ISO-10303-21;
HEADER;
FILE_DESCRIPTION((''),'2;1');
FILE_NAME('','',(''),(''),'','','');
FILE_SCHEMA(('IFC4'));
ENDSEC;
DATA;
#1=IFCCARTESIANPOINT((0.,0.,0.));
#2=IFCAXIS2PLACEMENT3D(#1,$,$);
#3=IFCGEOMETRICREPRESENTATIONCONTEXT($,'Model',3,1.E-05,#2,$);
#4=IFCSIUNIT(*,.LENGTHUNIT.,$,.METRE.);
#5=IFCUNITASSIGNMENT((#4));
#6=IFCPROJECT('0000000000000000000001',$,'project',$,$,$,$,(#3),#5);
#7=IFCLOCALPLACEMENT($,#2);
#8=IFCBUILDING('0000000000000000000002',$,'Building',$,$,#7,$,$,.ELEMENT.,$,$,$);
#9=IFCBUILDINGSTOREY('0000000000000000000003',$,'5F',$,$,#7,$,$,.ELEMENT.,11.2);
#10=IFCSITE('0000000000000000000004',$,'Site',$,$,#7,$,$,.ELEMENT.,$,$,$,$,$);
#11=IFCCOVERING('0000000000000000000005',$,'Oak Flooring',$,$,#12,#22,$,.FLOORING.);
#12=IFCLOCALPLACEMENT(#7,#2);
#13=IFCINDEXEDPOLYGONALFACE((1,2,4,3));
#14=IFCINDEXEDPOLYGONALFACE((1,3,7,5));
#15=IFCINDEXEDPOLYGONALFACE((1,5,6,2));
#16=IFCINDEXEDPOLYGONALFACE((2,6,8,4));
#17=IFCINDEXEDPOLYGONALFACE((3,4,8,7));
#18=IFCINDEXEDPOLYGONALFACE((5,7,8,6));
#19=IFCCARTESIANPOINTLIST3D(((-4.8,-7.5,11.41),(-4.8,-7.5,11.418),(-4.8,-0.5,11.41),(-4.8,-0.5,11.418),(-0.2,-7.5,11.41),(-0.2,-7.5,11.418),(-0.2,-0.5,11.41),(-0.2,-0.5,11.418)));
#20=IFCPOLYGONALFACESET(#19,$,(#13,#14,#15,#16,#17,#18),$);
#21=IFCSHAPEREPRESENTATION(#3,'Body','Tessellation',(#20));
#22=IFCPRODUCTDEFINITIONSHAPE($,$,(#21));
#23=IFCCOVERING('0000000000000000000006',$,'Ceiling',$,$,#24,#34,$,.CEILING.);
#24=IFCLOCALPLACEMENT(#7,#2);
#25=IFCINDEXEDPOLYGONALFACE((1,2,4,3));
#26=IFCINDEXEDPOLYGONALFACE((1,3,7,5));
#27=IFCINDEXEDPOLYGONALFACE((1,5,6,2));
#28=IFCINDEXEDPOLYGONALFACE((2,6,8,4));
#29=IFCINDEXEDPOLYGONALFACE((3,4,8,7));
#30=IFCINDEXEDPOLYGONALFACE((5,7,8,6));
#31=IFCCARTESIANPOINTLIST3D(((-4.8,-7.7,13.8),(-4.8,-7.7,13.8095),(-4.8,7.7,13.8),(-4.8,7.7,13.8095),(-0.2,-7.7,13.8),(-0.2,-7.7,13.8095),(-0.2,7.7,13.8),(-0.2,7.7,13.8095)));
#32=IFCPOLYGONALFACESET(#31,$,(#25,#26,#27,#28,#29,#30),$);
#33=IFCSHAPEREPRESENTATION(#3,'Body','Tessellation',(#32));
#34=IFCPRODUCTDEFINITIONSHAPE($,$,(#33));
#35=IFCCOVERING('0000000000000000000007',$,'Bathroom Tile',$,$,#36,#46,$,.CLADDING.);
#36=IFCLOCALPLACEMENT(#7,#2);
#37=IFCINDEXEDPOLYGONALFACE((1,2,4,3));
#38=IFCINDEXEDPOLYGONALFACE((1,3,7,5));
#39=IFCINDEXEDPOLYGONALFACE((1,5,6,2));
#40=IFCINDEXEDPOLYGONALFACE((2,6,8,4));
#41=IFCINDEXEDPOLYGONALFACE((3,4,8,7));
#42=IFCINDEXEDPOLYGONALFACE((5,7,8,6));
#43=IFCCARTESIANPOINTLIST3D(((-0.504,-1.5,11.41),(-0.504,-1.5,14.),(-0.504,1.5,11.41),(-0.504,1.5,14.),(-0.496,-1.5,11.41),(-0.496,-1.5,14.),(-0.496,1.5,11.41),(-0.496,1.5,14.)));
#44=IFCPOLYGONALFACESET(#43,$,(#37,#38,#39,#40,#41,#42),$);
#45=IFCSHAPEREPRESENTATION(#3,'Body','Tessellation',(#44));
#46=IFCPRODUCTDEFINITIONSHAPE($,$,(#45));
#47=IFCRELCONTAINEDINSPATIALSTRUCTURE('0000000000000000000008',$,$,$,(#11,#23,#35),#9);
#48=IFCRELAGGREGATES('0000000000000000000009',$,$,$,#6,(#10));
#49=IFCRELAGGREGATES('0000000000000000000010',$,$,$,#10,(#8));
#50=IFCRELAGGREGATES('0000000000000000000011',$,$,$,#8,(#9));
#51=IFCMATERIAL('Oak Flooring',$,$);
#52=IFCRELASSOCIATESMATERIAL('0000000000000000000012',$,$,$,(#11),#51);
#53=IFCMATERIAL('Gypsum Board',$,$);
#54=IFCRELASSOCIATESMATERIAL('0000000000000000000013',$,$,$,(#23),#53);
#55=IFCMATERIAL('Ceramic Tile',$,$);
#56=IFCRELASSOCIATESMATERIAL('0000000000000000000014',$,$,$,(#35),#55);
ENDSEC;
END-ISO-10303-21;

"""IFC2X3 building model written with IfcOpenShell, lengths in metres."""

from ifc_helpers import new_model, si_unit, frame, origin, origin_2d, place, context, project, spatial, rectangle, extrude, material, element, save


model = new_model("IFC2X3")

# Units and contexts
model_context = context("Model", 3, precision=1e-05, world=origin())
ifc_project = project(units=[si_unit("LENGTHUNIT", "METRE")], contexts=[model_context])

# Site, building, storey
placement = place(None, origin())
site = spatial("IfcSite", under=ifc_project, at=placement, Name="Site", CompositionType="ELEMENT")
building = spatial("IfcBuilding", under=site, at=placement, Name="Building", CompositionType="ELEMENT")
storey = spatial("IfcBuildingStorey", under=building, at=placement, Name="5F", CompositionType="ELEMENT", Elevation=11.2)

# Shared definitions
ifc_material_1 = material(Name="Gypsum Board")

# Coverings
ifc_material_2 = material(Name="Oak Flooring")
ifc_material_3 = material(Name="Ceramic Tile")
covering_1_placement = place(None, frame((-2.5, -4.0, 11.41)))
element("IfcCovering", 1, at=covering_1_placement, inside=storey, material=ifc_material_2, Name="Oak Flooring", PredefinedType="FLOORING", context=model_context, shape_type="SweptSolid", body=[
    extrude(rectangle(XDim=4.6, YDim=7.0, at=origin_2d()), origin(), (0.0, 0.0, 1.0), 0.008),
])
covering_2_placement = place(None, frame((-2.5, 0.0, 13.8)))
element("IfcCovering", 2, at=covering_2_placement, inside=storey, material=ifc_material_1, Name="Ceiling", PredefinedType="CEILING", context=model_context, shape_type="SweptSolid", body=[
    extrude(rectangle(XDim=4.6, YDim=15.4, at=origin_2d()), origin(), (0.0, 0.0, 1.0), 0.0095),
])
covering_3_placement = place(None, frame((-0.5, 0.0, 11.41)))
element("IfcCovering", 3, at=covering_3_placement, inside=storey, material=ifc_material_3, Name="Bathroom Tile", PredefinedType="CLADDING", context=model_context, shape_type="SweptSolid", body=[
    extrude(rectangle(XDim=0.008, YDim=3.0, at=origin_2d()), origin(), (0.0, 0.0, 1.0), 2.59),
])

save(model, "model.ifc")
